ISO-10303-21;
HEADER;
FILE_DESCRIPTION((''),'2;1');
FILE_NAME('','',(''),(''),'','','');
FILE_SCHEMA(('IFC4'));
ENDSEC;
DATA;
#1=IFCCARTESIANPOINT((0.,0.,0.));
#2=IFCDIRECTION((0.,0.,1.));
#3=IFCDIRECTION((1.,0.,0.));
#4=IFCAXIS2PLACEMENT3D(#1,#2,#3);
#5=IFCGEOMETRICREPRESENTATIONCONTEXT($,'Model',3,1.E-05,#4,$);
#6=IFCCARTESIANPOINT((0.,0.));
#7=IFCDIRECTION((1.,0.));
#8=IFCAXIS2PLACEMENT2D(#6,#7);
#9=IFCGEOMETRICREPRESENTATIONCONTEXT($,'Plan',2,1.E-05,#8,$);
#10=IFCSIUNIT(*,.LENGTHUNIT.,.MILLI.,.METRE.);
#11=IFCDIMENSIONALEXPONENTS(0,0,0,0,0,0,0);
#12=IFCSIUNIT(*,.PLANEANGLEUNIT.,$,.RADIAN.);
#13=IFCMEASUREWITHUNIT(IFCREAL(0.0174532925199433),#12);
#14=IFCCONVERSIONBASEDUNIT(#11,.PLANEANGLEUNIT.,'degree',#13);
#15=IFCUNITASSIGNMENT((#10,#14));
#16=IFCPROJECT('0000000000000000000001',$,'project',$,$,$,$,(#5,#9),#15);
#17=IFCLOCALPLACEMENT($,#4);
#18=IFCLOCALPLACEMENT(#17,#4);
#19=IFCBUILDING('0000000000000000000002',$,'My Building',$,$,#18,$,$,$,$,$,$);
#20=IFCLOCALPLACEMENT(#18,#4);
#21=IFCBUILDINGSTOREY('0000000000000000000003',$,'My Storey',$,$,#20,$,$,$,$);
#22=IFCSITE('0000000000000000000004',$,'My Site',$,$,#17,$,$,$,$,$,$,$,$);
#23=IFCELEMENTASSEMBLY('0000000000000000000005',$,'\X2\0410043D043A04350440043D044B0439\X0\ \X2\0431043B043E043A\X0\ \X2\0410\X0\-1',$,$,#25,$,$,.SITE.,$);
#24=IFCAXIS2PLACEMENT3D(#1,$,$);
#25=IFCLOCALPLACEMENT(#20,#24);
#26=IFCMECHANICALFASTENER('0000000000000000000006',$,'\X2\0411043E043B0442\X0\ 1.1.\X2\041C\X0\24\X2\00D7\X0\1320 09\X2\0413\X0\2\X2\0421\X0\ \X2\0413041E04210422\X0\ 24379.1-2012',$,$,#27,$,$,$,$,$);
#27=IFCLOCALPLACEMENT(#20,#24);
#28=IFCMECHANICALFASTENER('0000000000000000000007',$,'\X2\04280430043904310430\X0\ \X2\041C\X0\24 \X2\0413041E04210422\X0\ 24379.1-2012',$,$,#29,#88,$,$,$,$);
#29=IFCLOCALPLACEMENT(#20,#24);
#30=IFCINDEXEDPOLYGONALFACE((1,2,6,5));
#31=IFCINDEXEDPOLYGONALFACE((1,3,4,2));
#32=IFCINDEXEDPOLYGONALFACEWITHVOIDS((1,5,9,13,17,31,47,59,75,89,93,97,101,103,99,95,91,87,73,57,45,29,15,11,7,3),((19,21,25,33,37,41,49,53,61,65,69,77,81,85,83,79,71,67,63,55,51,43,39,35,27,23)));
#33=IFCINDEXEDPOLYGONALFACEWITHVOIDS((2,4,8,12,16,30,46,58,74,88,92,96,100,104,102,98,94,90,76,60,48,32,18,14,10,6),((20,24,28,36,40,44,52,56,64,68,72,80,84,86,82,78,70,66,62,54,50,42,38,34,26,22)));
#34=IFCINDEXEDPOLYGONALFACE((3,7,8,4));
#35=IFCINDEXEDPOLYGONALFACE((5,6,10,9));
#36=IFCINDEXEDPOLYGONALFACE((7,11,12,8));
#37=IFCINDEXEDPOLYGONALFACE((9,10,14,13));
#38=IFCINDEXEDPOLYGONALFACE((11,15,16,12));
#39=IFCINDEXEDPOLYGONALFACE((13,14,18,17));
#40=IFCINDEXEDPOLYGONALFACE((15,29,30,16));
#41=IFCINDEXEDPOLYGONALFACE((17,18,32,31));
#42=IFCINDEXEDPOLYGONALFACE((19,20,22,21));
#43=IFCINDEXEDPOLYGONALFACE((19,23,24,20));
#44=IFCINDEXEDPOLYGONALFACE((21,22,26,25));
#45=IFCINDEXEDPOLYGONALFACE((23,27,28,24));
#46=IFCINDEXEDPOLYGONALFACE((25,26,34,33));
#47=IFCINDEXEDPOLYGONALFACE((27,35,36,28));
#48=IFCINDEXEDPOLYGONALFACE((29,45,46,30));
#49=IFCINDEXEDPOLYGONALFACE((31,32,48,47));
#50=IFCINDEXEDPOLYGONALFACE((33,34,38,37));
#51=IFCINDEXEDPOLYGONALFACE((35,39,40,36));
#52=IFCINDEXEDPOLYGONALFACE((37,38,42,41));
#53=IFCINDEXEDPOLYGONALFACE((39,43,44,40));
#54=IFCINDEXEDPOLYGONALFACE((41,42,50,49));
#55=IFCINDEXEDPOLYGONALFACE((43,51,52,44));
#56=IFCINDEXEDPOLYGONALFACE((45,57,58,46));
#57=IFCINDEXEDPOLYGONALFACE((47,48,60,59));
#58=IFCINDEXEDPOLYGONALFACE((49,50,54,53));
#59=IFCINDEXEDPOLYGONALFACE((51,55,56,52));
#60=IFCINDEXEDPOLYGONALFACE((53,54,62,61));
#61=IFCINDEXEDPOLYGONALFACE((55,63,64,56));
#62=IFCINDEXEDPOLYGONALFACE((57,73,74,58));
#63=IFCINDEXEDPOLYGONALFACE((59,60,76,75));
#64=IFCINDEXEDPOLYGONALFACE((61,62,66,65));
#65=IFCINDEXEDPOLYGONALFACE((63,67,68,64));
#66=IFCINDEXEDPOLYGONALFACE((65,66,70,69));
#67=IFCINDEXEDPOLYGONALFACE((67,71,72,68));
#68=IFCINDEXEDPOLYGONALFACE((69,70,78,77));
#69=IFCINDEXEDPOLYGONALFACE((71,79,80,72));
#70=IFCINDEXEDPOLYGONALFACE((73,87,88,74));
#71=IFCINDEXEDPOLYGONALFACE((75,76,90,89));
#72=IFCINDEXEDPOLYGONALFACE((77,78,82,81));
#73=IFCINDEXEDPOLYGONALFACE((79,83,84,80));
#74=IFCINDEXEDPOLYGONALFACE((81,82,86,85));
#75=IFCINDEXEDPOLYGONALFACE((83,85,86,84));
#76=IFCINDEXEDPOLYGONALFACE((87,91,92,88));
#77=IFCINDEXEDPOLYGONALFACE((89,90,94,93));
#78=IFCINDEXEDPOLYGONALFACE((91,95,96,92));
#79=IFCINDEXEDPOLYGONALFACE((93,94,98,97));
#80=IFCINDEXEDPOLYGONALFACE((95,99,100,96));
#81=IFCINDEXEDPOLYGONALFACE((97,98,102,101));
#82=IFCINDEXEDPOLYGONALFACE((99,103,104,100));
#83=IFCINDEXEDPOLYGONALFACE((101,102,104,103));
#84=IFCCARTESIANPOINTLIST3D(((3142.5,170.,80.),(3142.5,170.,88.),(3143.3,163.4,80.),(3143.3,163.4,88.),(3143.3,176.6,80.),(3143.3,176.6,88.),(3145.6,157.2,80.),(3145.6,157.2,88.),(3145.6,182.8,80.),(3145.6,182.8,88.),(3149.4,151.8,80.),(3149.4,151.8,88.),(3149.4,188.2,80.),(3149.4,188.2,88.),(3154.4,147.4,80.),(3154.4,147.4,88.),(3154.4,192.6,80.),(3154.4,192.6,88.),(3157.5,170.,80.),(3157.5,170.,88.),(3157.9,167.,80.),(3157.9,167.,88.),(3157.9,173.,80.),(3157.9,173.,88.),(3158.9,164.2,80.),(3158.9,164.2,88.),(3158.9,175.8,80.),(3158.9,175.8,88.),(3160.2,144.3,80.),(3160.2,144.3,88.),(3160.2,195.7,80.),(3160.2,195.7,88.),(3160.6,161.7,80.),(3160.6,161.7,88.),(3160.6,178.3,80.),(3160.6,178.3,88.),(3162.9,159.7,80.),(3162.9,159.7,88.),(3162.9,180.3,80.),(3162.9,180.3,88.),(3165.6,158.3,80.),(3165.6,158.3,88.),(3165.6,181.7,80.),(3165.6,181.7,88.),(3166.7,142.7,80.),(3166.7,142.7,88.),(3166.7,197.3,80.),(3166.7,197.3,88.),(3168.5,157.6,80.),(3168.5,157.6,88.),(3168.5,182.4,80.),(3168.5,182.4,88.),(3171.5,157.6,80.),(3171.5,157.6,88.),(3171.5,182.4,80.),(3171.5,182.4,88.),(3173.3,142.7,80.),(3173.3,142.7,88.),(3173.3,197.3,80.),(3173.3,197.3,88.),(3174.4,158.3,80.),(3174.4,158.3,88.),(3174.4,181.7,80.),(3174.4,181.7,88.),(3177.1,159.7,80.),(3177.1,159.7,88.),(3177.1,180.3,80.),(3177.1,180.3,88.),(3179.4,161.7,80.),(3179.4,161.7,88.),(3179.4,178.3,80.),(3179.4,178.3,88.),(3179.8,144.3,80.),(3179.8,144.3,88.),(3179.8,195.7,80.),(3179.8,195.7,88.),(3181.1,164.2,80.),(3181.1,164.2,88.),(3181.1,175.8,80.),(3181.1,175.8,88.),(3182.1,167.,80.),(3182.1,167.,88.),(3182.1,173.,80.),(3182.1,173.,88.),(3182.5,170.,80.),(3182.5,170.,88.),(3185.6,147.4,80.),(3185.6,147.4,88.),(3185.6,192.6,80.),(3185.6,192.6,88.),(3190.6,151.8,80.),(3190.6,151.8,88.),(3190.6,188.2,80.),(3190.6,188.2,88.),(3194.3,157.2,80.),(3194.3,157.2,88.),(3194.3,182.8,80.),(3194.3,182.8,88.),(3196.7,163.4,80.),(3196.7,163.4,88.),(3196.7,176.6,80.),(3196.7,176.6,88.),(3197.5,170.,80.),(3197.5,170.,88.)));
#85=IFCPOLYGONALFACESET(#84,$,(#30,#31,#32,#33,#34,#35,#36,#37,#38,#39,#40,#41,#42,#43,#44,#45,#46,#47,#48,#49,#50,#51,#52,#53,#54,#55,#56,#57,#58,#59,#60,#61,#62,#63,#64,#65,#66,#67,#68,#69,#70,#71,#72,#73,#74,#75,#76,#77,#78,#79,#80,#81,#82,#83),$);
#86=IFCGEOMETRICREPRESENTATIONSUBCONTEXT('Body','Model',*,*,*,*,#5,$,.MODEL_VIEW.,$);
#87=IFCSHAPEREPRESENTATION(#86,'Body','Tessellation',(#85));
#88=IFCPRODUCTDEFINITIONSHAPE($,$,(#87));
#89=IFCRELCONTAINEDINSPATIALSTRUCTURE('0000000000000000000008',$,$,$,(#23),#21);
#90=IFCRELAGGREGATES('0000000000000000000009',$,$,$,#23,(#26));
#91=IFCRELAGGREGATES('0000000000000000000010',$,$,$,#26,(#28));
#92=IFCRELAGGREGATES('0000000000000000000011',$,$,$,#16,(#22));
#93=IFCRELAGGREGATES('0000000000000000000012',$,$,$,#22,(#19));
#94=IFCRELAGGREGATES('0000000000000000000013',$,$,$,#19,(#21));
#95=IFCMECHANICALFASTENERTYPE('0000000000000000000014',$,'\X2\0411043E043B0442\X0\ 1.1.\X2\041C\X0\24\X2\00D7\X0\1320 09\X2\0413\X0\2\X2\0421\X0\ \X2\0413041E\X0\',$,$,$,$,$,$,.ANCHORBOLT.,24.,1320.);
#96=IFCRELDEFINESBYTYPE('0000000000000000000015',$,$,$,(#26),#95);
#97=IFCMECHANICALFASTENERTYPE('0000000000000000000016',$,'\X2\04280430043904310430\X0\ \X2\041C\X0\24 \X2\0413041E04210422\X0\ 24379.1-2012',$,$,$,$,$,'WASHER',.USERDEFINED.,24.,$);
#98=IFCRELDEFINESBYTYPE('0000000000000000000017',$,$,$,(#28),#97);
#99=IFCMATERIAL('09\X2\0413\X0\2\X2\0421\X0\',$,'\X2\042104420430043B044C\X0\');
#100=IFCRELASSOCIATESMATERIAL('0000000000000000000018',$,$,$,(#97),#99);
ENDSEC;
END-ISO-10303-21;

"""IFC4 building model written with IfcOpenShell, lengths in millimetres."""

from ifc_helpers import new_model, entity, si_unit, converted_unit, frame, origin_with_axes, origin_2d_with_axis, place, context, subcontext, project, spatial, polyline, outline, extrude, source, transform, mapped, material, type_object, type_shapes, element, aggregate, save


model = new_model("IFC4")

# Units and contexts
model_context = context("Model", 3, precision=1e-05, world=origin_with_axes())
plan_context = context("Plan", 2, precision=1e-05, world=origin_2d_with_axis())
body_context = subcontext(model_context, "Body", "Model", "MODEL_VIEW")
ifc_project = project(units=[si_unit("LENGTHUNIT", "METRE", prefix="MILLI"), converted_unit("PLANEANGLEUNIT", "degree", entity("IfcReal", 0.0174532925199433), si_unit("PLANEANGLEUNIT", "RADIAN"), dimensions=[0, 0, 0, 0, 0, 0, 0])], contexts=[model_context, plan_context])

# Site, building, storey
site_placement = place(None, origin_with_axes())
site = spatial("IfcSite", under=ifc_project, at=site_placement, Name="My Site")
building_placement = place(site_placement, origin_with_axes())
building = spatial("IfcBuilding", under=site, at=building_placement, Name="My Building")
storey_placement = place(building_placement, origin_with_axes())
storey = spatial("IfcBuildingStorey", under=building, at=storey_placement, Name="My Storey")

# Element assembly, mechanical fasteners
assembly_placement = place(storey_placement, frame((3000.0, 0.0, 0.0), z_axis=(0.0, 0.0, 1.0), x_axis=(1.0, 0.0, 0.0)))
assembly = element("IfcElementAssembly", 1, at=assembly_placement, inside=storey, Name="Анкерный блок А-1", AssemblyPlace="SITE")
mechanical_fastener_type_1 = type_object("IfcMechanicalFastenerType", Name="Болт 1.1.М24×1320 09Г2С ГО", NominalDiameter=24.0, NominalLength=1320.0, PredefinedType="ANCHORBOLT")
ifc_material_1 = material(Name="09Г2С", Category="Сталь")
mechanical_fastener_1_placement = place(assembly_placement, frame((170.0, 170.0, 0.0), z_axis=(0.0, 0.0, 1.0), x_axis=(-1.0, 0.0, 0.0)))
mechanical_fastener_1 = element("IfcMechanicalFastener", 2, at=mechanical_fastener_1_placement, type_object=mechanical_fastener_type_1, Name="Болт 1.1.М24×1320 09Г2С ГОСТ 24379.1-2012")
aggregate(assembly, [mechanical_fastener_1])
mechanical_fastener_type_2 = type_object("IfcMechanicalFastenerType", Name="Шайба М24 ГОСТ 24379.1-2012", ElementType="WASHER", NominalDiameter=24.0, PredefinedType="USERDEFINED", material=ifc_material_1)
shared_shape_1 = source(origin_with_axes(), body_context, "Body", "SweptSolid", [
    extrude(outline(polyline([(27.5, 0.0), (26.7, 6.6), (24.4, 12.8), (20.6, 18.2), (15.6, 22.6), (9.8, 25.7), (3.3, 27.3), (-3.3, 27.3), (-9.8, 25.7), (-15.6, 22.6), (-20.6, 18.2), (-24.4, 12.8), (-26.7, 6.6), (-27.5, 0.0), (-26.7, -6.6), (-24.4, -12.8), (-20.6, -18.2), (-15.6, -22.6), (-9.8, -25.7), (-3.3, -27.3), (3.3, -27.3), (9.8, -25.7), (15.6, -22.6), (20.6, -18.2), (24.4, -12.8), (26.7, -6.6), (27.5, 0.0)]), holes=[polyline([(-4.4, -11.7), (-7.1, -10.3), (-9.4, -8.3), (-11.1, -5.8), (-12.1, -3.0), (-12.5, 0.0), (-12.1, 3.0), (-11.1, 5.8), (-9.4, 8.3), (-7.1, 10.3), (-4.4, 11.7), (-1.5, 12.4), (1.5, 12.4), (4.4, 11.7), (7.1, 10.3), (9.4, 8.3), (11.1, 5.8), (12.1, 3.0), (12.5, 0.0), (12.1, -3.0), (11.1, -5.8), (9.4, -8.3), (7.1, -10.3), (4.4, -11.7), (1.5, -12.4), (-1.5, -12.4), (-4.4, -11.7)])]), frame((0.0, 0.0, 0.0), z_axis=(0.0, 0.0, 1.0), x_axis=(0.120537, -0.992709, 0.0)), (0.0, 0.0, 1.0), 8.0),
])
type_shapes(mechanical_fastener_type_2, [shared_shape_1])
mechanical_fastener_2_placement = place(mechanical_fastener_1_placement, frame((0.0, 0.0, 80.0), z_axis=(0.0, 0.0, 1.0), x_axis=(1.0, 0.0, 0.0)))
mechanical_fastener_2 = element("IfcMechanicalFastener", 3, at=mechanical_fastener_2_placement, type_object=mechanical_fastener_type_2, Name="Шайба М24 ГОСТ 24379.1-2012", context=body_context, shape_type="MappedRepresentation", body=[
    mapped(shared_shape_1, transform((0.0, 0.0, 0.0), x_axis=(1.0, 0.0, 0.0), y_axis=(0.0, 1.0, 0.0), z_axis=(0.0, 0.0, 1.0), scale=1.0)),
])
aggregate(mechanical_fastener_1, [mechanical_fastener_2])

save(model, "model.ifc")
